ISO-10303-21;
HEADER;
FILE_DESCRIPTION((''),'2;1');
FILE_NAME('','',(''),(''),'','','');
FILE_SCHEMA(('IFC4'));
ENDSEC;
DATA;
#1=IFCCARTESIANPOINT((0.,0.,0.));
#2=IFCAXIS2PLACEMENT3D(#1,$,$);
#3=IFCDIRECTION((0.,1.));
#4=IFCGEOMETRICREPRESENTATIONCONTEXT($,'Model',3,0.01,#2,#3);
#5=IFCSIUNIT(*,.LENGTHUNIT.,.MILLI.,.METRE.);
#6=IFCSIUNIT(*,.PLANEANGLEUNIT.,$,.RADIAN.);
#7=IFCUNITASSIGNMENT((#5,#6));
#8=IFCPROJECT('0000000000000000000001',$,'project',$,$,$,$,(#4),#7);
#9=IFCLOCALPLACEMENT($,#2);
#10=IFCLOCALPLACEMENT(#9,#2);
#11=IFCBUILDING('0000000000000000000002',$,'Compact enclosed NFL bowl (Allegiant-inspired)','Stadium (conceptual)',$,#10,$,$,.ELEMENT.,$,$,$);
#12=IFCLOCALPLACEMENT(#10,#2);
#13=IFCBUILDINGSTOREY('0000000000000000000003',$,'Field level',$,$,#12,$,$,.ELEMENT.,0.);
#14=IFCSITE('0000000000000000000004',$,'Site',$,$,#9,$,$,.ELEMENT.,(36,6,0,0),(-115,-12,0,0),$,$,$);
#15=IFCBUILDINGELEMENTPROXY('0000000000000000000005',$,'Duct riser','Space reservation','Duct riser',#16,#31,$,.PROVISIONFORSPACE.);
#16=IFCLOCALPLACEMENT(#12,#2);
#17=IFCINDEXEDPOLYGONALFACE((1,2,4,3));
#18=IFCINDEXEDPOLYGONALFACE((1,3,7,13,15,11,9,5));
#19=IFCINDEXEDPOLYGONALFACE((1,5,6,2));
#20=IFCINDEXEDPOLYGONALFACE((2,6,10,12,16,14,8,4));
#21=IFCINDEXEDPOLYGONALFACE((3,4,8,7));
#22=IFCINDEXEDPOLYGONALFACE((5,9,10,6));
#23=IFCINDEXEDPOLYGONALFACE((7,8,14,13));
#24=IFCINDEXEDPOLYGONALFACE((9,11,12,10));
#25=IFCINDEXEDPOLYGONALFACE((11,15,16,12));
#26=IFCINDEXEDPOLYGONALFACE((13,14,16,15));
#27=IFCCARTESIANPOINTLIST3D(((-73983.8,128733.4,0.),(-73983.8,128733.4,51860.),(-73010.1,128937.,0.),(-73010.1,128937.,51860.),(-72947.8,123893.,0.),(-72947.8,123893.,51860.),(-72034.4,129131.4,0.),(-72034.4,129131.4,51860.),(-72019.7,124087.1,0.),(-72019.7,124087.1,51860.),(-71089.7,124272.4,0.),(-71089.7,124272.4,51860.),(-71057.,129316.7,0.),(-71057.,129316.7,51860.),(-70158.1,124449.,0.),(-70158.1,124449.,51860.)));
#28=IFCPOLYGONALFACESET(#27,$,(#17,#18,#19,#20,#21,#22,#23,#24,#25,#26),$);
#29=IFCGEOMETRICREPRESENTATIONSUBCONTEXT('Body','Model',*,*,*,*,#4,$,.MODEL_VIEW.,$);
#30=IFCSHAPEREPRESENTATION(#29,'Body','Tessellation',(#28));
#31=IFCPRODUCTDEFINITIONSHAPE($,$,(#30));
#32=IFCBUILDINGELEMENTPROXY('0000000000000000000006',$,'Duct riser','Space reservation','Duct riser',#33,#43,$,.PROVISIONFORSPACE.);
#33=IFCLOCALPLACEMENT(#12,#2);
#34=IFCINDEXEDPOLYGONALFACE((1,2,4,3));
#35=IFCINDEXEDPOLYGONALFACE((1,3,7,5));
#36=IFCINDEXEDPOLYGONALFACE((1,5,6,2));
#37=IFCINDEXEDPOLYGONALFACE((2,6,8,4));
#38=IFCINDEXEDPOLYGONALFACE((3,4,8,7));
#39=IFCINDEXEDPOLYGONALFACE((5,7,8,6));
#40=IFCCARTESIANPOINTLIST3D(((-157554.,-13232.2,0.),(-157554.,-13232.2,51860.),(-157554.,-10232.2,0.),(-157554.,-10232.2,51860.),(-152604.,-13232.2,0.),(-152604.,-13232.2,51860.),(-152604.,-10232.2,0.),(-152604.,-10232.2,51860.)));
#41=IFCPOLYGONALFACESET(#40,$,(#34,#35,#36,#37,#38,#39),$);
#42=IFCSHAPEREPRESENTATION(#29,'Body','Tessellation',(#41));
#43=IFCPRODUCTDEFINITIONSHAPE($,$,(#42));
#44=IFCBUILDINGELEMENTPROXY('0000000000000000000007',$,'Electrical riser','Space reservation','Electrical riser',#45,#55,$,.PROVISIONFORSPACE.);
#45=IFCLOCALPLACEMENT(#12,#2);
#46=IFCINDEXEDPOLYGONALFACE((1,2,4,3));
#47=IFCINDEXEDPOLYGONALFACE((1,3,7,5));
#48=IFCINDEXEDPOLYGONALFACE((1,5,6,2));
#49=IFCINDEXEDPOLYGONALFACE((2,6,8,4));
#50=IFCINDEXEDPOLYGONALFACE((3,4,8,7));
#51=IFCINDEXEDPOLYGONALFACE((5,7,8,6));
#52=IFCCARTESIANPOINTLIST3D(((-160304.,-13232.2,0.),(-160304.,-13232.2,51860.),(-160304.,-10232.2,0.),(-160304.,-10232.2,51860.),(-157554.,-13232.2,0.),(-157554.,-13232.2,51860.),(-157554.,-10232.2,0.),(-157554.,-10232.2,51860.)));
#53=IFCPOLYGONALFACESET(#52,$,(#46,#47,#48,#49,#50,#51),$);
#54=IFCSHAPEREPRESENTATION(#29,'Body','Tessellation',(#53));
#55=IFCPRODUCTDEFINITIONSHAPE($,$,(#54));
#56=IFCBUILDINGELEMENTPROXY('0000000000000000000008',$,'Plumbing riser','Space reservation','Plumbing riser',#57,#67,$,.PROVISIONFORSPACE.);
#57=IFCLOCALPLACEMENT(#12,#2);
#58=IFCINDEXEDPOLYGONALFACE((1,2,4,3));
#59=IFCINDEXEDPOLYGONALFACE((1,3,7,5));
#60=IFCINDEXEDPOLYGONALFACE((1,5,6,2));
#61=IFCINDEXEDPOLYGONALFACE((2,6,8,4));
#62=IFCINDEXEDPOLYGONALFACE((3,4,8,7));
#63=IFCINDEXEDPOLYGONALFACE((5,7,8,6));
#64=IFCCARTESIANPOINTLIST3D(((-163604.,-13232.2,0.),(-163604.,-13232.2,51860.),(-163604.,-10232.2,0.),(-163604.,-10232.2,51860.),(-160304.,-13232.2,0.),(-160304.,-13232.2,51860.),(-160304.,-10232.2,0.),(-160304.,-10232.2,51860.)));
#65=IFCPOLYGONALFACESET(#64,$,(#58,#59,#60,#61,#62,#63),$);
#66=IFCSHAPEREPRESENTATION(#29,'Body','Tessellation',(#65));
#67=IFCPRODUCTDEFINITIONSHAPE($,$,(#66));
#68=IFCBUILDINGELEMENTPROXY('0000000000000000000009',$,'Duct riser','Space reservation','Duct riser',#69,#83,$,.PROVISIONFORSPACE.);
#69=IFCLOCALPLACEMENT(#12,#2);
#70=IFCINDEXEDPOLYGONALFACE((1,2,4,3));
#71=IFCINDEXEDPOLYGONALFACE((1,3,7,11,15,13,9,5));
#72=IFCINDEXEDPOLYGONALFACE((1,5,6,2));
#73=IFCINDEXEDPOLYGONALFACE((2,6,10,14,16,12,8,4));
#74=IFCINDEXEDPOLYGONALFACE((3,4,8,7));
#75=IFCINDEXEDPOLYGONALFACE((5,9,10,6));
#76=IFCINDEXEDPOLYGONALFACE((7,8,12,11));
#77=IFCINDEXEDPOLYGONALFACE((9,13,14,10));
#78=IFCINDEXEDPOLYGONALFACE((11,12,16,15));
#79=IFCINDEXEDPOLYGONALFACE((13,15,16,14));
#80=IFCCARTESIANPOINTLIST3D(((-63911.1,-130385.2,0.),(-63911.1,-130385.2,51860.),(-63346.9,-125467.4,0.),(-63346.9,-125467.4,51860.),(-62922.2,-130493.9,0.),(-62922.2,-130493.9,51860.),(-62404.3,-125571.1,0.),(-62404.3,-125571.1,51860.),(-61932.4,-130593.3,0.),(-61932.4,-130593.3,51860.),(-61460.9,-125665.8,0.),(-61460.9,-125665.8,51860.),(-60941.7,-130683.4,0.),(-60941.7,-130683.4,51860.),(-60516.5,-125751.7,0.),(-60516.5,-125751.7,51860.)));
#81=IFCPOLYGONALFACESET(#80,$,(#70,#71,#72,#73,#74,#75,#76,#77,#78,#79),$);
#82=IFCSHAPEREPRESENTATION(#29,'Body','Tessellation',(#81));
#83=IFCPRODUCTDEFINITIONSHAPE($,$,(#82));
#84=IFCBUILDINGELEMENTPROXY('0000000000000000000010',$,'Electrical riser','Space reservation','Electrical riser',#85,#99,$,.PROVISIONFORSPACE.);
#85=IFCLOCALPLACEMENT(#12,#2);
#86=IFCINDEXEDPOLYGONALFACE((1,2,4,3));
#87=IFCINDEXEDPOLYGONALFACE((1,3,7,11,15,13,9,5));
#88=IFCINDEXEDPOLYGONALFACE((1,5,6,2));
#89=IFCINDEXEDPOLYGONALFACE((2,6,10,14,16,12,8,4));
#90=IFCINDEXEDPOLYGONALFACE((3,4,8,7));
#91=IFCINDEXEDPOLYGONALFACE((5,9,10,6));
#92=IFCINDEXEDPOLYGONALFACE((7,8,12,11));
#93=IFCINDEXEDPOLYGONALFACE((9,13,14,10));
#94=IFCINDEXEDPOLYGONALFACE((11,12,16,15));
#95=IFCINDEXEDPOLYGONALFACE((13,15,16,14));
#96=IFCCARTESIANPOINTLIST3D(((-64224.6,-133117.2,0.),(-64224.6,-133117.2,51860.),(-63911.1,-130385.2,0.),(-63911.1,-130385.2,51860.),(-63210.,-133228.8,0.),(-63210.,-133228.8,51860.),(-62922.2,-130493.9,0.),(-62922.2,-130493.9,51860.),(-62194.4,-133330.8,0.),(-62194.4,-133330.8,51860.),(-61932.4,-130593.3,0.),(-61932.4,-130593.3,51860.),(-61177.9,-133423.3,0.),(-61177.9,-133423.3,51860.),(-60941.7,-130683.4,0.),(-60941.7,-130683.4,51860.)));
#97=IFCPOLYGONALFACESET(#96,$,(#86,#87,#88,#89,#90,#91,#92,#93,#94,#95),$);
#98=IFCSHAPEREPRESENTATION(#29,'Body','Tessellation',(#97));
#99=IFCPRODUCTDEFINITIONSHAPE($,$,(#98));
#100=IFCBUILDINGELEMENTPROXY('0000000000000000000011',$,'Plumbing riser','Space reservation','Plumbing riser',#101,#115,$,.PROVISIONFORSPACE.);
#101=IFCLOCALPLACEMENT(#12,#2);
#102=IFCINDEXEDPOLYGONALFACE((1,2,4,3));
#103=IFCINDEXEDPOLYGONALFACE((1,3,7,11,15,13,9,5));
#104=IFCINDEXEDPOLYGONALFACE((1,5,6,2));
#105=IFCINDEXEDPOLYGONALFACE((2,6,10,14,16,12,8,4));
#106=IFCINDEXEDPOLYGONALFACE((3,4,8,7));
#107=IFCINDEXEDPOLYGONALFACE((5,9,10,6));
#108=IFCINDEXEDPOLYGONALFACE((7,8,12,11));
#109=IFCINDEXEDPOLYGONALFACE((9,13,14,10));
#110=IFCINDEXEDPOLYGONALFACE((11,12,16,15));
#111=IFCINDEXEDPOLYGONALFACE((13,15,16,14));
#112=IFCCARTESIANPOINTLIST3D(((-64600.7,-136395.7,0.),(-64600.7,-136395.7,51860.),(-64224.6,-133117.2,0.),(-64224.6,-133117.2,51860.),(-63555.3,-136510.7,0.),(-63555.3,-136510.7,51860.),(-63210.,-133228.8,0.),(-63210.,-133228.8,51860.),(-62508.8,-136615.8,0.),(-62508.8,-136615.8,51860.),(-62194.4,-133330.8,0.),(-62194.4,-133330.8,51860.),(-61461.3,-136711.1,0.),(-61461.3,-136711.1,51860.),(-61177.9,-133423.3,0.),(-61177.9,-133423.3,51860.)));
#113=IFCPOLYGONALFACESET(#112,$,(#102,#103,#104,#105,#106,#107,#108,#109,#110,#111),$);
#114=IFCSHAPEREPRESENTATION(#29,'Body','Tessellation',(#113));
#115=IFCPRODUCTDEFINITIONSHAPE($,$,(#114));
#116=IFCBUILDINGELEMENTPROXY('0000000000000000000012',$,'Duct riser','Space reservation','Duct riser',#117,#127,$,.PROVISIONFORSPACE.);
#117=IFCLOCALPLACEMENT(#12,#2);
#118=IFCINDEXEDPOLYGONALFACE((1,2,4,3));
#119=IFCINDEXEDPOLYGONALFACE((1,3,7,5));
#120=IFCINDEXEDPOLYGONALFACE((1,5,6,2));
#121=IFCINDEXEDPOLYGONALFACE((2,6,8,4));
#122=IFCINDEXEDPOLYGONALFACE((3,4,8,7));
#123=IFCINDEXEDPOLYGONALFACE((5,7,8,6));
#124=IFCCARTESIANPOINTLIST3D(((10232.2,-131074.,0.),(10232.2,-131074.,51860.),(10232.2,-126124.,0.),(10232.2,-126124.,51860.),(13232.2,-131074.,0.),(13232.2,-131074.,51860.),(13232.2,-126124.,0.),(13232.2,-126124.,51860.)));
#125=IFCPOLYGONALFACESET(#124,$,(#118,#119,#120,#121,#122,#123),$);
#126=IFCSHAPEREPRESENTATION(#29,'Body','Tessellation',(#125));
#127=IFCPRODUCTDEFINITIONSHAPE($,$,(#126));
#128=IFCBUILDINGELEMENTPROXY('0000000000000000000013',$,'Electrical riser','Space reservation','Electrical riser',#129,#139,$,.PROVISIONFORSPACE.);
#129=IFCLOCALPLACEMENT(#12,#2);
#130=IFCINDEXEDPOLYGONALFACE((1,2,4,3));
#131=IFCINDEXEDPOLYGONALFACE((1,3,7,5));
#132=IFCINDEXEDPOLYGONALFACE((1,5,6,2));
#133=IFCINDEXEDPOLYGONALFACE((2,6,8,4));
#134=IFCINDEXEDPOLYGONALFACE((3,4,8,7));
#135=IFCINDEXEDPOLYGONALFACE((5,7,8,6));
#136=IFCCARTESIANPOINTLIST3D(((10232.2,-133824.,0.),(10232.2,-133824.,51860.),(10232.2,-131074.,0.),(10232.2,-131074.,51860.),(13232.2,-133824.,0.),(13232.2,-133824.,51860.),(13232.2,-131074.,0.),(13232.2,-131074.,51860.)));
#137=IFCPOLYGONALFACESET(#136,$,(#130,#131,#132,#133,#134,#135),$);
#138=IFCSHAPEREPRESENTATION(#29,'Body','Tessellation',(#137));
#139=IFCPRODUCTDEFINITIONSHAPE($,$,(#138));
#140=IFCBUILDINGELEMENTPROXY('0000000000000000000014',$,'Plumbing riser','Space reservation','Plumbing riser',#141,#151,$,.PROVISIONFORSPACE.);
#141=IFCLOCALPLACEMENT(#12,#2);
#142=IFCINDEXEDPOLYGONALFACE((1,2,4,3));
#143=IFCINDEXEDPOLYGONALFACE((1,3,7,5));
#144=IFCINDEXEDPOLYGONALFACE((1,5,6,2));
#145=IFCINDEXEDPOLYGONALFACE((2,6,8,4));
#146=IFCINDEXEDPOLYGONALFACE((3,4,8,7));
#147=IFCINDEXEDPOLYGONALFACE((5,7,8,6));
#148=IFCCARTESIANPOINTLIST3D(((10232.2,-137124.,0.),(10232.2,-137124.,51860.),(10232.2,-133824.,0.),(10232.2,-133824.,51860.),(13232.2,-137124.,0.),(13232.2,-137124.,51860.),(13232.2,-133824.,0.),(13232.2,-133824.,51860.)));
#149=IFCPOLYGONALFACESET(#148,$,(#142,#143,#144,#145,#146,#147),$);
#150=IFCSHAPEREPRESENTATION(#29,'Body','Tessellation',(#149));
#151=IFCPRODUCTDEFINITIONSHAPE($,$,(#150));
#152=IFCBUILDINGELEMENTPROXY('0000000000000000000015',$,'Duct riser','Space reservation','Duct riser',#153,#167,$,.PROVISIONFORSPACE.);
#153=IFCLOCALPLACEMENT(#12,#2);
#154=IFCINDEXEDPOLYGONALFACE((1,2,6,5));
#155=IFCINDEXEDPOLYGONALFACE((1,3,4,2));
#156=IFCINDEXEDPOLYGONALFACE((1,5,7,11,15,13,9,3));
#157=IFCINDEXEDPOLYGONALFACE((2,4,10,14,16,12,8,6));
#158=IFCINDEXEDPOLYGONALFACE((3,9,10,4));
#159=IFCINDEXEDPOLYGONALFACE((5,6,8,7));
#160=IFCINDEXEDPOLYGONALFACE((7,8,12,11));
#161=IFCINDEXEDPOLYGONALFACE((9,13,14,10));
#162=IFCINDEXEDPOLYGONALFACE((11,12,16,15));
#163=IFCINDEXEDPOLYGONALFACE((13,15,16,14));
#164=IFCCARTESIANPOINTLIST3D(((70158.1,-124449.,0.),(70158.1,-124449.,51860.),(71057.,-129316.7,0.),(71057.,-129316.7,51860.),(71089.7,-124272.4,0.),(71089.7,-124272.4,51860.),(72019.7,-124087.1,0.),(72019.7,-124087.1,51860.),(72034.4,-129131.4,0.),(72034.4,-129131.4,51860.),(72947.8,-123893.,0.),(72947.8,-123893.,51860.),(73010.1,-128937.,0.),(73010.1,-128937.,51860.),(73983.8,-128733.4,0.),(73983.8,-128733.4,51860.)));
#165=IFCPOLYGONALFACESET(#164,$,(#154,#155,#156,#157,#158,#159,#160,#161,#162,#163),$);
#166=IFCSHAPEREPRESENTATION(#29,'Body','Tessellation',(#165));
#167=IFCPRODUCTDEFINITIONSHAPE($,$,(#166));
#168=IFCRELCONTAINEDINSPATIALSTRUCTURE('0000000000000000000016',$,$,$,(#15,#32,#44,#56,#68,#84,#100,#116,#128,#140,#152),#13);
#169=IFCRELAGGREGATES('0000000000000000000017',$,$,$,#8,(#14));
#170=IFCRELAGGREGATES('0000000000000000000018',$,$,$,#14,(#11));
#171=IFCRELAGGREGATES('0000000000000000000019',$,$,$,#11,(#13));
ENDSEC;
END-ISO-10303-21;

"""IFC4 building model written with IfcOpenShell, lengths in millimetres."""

from ifc_helpers import new_model, si_unit, direction, origin, place, context, subcontext, project, spatial, line, arc, indexed_curve, outline, extrude, element, save


model = new_model("IFC4")

# Units and contexts
model_context = context("Model", 3, precision=0.01, world=origin(), true_north=direction((0.0, 1.0)))
body_context = subcontext(model_context, "Body", "Model", "MODEL_VIEW")
ifc_project = project(units=[si_unit("LENGTHUNIT", "METRE", prefix="MILLI"), si_unit("PLANEANGLEUNIT", "RADIAN")], contexts=[model_context])

# Site, building, storey
site_placement = place(None, origin())
site = spatial("IfcSite", under=ifc_project, at=site_placement, Name="Site", CompositionType="ELEMENT", RefLatitude=(36, 6, 0, 0), RefLongitude=(-115, -12, 0, 0))
building_placement = place(site_placement, origin())
building = spatial("IfcBuilding", under=site, at=building_placement, Name="Compact enclosed NFL bowl (Allegiant-inspired)", Description="Stadium (conceptual)", CompositionType="ELEMENT")
storey_placement = place(building_placement, origin())
storey = spatial("IfcBuildingStorey", under=building, at=storey_placement, Name="Field level", CompositionType="ELEMENT", Elevation=0.0)

# Building element proxies
placement = place(storey_placement, origin())
element("IfcBuildingElementProxy", 1, at=placement, inside=storey, Name="Duct riser", Description="Space reservation", ObjectType="Duct riser", PredefinedType="PROVISIONFORSPACE", context=body_context, shape_type="SweptSolid", body=[
    extrude(outline(indexed_curve([(-70158.1, 124449.0), (-71554.9, 124180.8), (-72947.8, 123893.0), (-73983.8, 128733.4), (-72522.5, 129035.4), (-71057.0, 129316.7)], segments=[arc(1, 2, 3), line(3, 4), arc(4, 5, 6), line(6, 1)], self_intersect=False)), origin(), (0.0, 0.0, 1.0), 51860.0),
])
element("IfcBuildingElementProxy", 2, at=placement, inside=storey, Name="Duct riser", Description="Space reservation", ObjectType="Duct riser", PredefinedType="PROVISIONFORSPACE", context=body_context, shape_type="SweptSolid", body=[
    extrude(outline(indexed_curve([(-152604.0, -10232.2), (-152604.0, -13232.2), (-157554.0, -13232.2), (-157554.0, -10232.2)], segments=[line(1, 2), line(2, 3), line(3, 4), line(4, 1)], self_intersect=False)), origin(), (0.0, 0.0, 1.0), 51860.0),
])
element("IfcBuildingElementProxy", 3, at=placement, inside=storey, Name="Electrical riser", Description="Space reservation", ObjectType="Electrical riser", PredefinedType="PROVISIONFORSPACE", context=body_context, shape_type="SweptSolid", body=[
    extrude(outline(indexed_curve([(-157554.0, -10232.2), (-157554.0, -13232.2), (-160304.0, -13232.2), (-160304.0, -10232.2)], segments=[line(1, 2), line(2, 3), line(3, 4), line(4, 1)], self_intersect=False)), origin(), (0.0, 0.0, 1.0), 51860.0),
])
element("IfcBuildingElementProxy", 4, at=placement, inside=storey, Name="Plumbing riser", Description="Space reservation", ObjectType="Plumbing riser", PredefinedType="PROVISIONFORSPACE", context=body_context, shape_type="SweptSolid", body=[
    extrude(outline(indexed_curve([(-160304.0, -10232.2), (-160304.0, -13232.2), (-163604.0, -13232.2), (-163604.0, -10232.2)], segments=[line(1, 2), line(2, 3), line(3, 4), line(4, 1)], self_intersect=False)), origin(), (0.0, 0.0, 1.0), 51860.0),
])
element("IfcBuildingElementProxy", 5, at=placement, inside=storey, Name="Duct riser", Description="Space reservation", ObjectType="Duct riser", PredefinedType="PROVISIONFORSPACE", context=body_context, shape_type="SweptSolid", body=[
    extrude(outline(indexed_curve([(-63346.9, -125467.4), (-61932.7, -125619.6), (-60516.5, -125751.7), (-60941.7, -130683.4), (-62427.4, -130544.8), (-63911.1, -130385.2)], segments=[arc(1, 2, 3), line(3, 4), arc(4, 5, 6), line(6, 1)], self_intersect=False)), origin(), (0.0, 0.0, 1.0), 51860.0),
])
element("IfcBuildingElementProxy", 6, at=placement, inside=storey, Name="Electrical riser", Description="Space reservation", ObjectType="Electrical riser", PredefinedType="PROVISIONFORSPACE", context=body_context, shape_type="SweptSolid", body=[
    extrude(outline(indexed_curve([(-63911.1, -130385.2), (-62427.4, -130544.8), (-60941.7, -130683.4), (-61177.9, -133423.3), (-62702.3, -133281.0), (-64224.6, -133117.2)], segments=[arc(1, 2, 3), line(3, 4), arc(4, 5, 6), line(6, 1)], self_intersect=False)), origin(), (0.0, 0.0, 1.0), 51860.0),
])
element("IfcBuildingElementProxy", 7, at=placement, inside=storey, Name="Plumbing riser", Description="Space reservation", ObjectType="Plumbing riser", PredefinedType="PROVISIONFORSPACE", context=body_context, shape_type="SweptSolid", body=[
    extrude(outline(indexed_curve([(-64224.6, -133117.2), (-62702.3, -133281.0), (-61177.9, -133423.3), (-61461.3, -136711.1), (-63032.1, -136564.5), (-64600.7, -136395.7)], segments=[arc(1, 2, 3), line(3, 4), arc(4, 5, 6), line(6, 1)], self_intersect=False)), origin(), (0.0, 0.0, 1.0), 51860.0),
])
element("IfcBuildingElementProxy", 8, at=placement, inside=storey, Name="Duct riser", Description="Space reservation", ObjectType="Duct riser", PredefinedType="PROVISIONFORSPACE", context=body_context, shape_type="SweptSolid", body=[
    extrude(outline(indexed_curve([(10232.2, -126124.0), (13232.2, -126124.0), (13232.2, -131074.0), (10232.2, -131074.0)], segments=[line(1, 2), line(2, 3), line(3, 4), line(4, 1)], self_intersect=False)), origin(), (0.0, 0.0, 1.0), 51860.0),
])
element("IfcBuildingElementProxy", 9, at=placement, inside=storey, Name="Electrical riser", Description="Space reservation", ObjectType="Electrical riser", PredefinedType="PROVISIONFORSPACE", context=body_context, shape_type="SweptSolid", body=[
    extrude(outline(indexed_curve([(10232.2, -131074.0), (13232.2, -131074.0), (13232.2, -133824.0), (10232.2, -133824.0)], segments=[line(1, 2), line(2, 3), line(3, 4), line(4, 1)], self_intersect=False)), origin(), (0.0, 0.0, 1.0), 51860.0),
])
element("IfcBuildingElementProxy", 10, at=placement, inside=storey, Name="Plumbing riser", Description="Space reservation", ObjectType="Plumbing riser", PredefinedType="PROVISIONFORSPACE", context=body_context, shape_type="SweptSolid", body=[
    extrude(outline(indexed_curve([(10232.2, -133824.0), (13232.2, -133824.0), (13232.2, -137124.0), (10232.2, -137124.0)], segments=[line(1, 2), line(2, 3), line(3, 4), line(4, 1)], self_intersect=False)), origin(), (0.0, 0.0, 1.0), 51860.0),
])
element("IfcBuildingElementProxy", 11, at=placement, inside=storey, Name="Duct riser", Description="Space reservation", ObjectType="Duct riser", PredefinedType="PROVISIONFORSPACE", context=body_context, shape_type="SweptSolid", body=[
    extrude(outline(indexed_curve([(70158.1, -124449.0), (71554.9, -124180.8), (72947.8, -123893.0), (73983.8, -128733.4), (72522.5, -129035.4), (71057.0, -129316.7)], segments=[arc(1, 2, 3), line(3, 4), arc(4, 5, 6), line(6, 1)], self_intersect=False)), origin(), (0.0, 0.0, 1.0), 51860.0),
])

save(model, "model.ifc")
